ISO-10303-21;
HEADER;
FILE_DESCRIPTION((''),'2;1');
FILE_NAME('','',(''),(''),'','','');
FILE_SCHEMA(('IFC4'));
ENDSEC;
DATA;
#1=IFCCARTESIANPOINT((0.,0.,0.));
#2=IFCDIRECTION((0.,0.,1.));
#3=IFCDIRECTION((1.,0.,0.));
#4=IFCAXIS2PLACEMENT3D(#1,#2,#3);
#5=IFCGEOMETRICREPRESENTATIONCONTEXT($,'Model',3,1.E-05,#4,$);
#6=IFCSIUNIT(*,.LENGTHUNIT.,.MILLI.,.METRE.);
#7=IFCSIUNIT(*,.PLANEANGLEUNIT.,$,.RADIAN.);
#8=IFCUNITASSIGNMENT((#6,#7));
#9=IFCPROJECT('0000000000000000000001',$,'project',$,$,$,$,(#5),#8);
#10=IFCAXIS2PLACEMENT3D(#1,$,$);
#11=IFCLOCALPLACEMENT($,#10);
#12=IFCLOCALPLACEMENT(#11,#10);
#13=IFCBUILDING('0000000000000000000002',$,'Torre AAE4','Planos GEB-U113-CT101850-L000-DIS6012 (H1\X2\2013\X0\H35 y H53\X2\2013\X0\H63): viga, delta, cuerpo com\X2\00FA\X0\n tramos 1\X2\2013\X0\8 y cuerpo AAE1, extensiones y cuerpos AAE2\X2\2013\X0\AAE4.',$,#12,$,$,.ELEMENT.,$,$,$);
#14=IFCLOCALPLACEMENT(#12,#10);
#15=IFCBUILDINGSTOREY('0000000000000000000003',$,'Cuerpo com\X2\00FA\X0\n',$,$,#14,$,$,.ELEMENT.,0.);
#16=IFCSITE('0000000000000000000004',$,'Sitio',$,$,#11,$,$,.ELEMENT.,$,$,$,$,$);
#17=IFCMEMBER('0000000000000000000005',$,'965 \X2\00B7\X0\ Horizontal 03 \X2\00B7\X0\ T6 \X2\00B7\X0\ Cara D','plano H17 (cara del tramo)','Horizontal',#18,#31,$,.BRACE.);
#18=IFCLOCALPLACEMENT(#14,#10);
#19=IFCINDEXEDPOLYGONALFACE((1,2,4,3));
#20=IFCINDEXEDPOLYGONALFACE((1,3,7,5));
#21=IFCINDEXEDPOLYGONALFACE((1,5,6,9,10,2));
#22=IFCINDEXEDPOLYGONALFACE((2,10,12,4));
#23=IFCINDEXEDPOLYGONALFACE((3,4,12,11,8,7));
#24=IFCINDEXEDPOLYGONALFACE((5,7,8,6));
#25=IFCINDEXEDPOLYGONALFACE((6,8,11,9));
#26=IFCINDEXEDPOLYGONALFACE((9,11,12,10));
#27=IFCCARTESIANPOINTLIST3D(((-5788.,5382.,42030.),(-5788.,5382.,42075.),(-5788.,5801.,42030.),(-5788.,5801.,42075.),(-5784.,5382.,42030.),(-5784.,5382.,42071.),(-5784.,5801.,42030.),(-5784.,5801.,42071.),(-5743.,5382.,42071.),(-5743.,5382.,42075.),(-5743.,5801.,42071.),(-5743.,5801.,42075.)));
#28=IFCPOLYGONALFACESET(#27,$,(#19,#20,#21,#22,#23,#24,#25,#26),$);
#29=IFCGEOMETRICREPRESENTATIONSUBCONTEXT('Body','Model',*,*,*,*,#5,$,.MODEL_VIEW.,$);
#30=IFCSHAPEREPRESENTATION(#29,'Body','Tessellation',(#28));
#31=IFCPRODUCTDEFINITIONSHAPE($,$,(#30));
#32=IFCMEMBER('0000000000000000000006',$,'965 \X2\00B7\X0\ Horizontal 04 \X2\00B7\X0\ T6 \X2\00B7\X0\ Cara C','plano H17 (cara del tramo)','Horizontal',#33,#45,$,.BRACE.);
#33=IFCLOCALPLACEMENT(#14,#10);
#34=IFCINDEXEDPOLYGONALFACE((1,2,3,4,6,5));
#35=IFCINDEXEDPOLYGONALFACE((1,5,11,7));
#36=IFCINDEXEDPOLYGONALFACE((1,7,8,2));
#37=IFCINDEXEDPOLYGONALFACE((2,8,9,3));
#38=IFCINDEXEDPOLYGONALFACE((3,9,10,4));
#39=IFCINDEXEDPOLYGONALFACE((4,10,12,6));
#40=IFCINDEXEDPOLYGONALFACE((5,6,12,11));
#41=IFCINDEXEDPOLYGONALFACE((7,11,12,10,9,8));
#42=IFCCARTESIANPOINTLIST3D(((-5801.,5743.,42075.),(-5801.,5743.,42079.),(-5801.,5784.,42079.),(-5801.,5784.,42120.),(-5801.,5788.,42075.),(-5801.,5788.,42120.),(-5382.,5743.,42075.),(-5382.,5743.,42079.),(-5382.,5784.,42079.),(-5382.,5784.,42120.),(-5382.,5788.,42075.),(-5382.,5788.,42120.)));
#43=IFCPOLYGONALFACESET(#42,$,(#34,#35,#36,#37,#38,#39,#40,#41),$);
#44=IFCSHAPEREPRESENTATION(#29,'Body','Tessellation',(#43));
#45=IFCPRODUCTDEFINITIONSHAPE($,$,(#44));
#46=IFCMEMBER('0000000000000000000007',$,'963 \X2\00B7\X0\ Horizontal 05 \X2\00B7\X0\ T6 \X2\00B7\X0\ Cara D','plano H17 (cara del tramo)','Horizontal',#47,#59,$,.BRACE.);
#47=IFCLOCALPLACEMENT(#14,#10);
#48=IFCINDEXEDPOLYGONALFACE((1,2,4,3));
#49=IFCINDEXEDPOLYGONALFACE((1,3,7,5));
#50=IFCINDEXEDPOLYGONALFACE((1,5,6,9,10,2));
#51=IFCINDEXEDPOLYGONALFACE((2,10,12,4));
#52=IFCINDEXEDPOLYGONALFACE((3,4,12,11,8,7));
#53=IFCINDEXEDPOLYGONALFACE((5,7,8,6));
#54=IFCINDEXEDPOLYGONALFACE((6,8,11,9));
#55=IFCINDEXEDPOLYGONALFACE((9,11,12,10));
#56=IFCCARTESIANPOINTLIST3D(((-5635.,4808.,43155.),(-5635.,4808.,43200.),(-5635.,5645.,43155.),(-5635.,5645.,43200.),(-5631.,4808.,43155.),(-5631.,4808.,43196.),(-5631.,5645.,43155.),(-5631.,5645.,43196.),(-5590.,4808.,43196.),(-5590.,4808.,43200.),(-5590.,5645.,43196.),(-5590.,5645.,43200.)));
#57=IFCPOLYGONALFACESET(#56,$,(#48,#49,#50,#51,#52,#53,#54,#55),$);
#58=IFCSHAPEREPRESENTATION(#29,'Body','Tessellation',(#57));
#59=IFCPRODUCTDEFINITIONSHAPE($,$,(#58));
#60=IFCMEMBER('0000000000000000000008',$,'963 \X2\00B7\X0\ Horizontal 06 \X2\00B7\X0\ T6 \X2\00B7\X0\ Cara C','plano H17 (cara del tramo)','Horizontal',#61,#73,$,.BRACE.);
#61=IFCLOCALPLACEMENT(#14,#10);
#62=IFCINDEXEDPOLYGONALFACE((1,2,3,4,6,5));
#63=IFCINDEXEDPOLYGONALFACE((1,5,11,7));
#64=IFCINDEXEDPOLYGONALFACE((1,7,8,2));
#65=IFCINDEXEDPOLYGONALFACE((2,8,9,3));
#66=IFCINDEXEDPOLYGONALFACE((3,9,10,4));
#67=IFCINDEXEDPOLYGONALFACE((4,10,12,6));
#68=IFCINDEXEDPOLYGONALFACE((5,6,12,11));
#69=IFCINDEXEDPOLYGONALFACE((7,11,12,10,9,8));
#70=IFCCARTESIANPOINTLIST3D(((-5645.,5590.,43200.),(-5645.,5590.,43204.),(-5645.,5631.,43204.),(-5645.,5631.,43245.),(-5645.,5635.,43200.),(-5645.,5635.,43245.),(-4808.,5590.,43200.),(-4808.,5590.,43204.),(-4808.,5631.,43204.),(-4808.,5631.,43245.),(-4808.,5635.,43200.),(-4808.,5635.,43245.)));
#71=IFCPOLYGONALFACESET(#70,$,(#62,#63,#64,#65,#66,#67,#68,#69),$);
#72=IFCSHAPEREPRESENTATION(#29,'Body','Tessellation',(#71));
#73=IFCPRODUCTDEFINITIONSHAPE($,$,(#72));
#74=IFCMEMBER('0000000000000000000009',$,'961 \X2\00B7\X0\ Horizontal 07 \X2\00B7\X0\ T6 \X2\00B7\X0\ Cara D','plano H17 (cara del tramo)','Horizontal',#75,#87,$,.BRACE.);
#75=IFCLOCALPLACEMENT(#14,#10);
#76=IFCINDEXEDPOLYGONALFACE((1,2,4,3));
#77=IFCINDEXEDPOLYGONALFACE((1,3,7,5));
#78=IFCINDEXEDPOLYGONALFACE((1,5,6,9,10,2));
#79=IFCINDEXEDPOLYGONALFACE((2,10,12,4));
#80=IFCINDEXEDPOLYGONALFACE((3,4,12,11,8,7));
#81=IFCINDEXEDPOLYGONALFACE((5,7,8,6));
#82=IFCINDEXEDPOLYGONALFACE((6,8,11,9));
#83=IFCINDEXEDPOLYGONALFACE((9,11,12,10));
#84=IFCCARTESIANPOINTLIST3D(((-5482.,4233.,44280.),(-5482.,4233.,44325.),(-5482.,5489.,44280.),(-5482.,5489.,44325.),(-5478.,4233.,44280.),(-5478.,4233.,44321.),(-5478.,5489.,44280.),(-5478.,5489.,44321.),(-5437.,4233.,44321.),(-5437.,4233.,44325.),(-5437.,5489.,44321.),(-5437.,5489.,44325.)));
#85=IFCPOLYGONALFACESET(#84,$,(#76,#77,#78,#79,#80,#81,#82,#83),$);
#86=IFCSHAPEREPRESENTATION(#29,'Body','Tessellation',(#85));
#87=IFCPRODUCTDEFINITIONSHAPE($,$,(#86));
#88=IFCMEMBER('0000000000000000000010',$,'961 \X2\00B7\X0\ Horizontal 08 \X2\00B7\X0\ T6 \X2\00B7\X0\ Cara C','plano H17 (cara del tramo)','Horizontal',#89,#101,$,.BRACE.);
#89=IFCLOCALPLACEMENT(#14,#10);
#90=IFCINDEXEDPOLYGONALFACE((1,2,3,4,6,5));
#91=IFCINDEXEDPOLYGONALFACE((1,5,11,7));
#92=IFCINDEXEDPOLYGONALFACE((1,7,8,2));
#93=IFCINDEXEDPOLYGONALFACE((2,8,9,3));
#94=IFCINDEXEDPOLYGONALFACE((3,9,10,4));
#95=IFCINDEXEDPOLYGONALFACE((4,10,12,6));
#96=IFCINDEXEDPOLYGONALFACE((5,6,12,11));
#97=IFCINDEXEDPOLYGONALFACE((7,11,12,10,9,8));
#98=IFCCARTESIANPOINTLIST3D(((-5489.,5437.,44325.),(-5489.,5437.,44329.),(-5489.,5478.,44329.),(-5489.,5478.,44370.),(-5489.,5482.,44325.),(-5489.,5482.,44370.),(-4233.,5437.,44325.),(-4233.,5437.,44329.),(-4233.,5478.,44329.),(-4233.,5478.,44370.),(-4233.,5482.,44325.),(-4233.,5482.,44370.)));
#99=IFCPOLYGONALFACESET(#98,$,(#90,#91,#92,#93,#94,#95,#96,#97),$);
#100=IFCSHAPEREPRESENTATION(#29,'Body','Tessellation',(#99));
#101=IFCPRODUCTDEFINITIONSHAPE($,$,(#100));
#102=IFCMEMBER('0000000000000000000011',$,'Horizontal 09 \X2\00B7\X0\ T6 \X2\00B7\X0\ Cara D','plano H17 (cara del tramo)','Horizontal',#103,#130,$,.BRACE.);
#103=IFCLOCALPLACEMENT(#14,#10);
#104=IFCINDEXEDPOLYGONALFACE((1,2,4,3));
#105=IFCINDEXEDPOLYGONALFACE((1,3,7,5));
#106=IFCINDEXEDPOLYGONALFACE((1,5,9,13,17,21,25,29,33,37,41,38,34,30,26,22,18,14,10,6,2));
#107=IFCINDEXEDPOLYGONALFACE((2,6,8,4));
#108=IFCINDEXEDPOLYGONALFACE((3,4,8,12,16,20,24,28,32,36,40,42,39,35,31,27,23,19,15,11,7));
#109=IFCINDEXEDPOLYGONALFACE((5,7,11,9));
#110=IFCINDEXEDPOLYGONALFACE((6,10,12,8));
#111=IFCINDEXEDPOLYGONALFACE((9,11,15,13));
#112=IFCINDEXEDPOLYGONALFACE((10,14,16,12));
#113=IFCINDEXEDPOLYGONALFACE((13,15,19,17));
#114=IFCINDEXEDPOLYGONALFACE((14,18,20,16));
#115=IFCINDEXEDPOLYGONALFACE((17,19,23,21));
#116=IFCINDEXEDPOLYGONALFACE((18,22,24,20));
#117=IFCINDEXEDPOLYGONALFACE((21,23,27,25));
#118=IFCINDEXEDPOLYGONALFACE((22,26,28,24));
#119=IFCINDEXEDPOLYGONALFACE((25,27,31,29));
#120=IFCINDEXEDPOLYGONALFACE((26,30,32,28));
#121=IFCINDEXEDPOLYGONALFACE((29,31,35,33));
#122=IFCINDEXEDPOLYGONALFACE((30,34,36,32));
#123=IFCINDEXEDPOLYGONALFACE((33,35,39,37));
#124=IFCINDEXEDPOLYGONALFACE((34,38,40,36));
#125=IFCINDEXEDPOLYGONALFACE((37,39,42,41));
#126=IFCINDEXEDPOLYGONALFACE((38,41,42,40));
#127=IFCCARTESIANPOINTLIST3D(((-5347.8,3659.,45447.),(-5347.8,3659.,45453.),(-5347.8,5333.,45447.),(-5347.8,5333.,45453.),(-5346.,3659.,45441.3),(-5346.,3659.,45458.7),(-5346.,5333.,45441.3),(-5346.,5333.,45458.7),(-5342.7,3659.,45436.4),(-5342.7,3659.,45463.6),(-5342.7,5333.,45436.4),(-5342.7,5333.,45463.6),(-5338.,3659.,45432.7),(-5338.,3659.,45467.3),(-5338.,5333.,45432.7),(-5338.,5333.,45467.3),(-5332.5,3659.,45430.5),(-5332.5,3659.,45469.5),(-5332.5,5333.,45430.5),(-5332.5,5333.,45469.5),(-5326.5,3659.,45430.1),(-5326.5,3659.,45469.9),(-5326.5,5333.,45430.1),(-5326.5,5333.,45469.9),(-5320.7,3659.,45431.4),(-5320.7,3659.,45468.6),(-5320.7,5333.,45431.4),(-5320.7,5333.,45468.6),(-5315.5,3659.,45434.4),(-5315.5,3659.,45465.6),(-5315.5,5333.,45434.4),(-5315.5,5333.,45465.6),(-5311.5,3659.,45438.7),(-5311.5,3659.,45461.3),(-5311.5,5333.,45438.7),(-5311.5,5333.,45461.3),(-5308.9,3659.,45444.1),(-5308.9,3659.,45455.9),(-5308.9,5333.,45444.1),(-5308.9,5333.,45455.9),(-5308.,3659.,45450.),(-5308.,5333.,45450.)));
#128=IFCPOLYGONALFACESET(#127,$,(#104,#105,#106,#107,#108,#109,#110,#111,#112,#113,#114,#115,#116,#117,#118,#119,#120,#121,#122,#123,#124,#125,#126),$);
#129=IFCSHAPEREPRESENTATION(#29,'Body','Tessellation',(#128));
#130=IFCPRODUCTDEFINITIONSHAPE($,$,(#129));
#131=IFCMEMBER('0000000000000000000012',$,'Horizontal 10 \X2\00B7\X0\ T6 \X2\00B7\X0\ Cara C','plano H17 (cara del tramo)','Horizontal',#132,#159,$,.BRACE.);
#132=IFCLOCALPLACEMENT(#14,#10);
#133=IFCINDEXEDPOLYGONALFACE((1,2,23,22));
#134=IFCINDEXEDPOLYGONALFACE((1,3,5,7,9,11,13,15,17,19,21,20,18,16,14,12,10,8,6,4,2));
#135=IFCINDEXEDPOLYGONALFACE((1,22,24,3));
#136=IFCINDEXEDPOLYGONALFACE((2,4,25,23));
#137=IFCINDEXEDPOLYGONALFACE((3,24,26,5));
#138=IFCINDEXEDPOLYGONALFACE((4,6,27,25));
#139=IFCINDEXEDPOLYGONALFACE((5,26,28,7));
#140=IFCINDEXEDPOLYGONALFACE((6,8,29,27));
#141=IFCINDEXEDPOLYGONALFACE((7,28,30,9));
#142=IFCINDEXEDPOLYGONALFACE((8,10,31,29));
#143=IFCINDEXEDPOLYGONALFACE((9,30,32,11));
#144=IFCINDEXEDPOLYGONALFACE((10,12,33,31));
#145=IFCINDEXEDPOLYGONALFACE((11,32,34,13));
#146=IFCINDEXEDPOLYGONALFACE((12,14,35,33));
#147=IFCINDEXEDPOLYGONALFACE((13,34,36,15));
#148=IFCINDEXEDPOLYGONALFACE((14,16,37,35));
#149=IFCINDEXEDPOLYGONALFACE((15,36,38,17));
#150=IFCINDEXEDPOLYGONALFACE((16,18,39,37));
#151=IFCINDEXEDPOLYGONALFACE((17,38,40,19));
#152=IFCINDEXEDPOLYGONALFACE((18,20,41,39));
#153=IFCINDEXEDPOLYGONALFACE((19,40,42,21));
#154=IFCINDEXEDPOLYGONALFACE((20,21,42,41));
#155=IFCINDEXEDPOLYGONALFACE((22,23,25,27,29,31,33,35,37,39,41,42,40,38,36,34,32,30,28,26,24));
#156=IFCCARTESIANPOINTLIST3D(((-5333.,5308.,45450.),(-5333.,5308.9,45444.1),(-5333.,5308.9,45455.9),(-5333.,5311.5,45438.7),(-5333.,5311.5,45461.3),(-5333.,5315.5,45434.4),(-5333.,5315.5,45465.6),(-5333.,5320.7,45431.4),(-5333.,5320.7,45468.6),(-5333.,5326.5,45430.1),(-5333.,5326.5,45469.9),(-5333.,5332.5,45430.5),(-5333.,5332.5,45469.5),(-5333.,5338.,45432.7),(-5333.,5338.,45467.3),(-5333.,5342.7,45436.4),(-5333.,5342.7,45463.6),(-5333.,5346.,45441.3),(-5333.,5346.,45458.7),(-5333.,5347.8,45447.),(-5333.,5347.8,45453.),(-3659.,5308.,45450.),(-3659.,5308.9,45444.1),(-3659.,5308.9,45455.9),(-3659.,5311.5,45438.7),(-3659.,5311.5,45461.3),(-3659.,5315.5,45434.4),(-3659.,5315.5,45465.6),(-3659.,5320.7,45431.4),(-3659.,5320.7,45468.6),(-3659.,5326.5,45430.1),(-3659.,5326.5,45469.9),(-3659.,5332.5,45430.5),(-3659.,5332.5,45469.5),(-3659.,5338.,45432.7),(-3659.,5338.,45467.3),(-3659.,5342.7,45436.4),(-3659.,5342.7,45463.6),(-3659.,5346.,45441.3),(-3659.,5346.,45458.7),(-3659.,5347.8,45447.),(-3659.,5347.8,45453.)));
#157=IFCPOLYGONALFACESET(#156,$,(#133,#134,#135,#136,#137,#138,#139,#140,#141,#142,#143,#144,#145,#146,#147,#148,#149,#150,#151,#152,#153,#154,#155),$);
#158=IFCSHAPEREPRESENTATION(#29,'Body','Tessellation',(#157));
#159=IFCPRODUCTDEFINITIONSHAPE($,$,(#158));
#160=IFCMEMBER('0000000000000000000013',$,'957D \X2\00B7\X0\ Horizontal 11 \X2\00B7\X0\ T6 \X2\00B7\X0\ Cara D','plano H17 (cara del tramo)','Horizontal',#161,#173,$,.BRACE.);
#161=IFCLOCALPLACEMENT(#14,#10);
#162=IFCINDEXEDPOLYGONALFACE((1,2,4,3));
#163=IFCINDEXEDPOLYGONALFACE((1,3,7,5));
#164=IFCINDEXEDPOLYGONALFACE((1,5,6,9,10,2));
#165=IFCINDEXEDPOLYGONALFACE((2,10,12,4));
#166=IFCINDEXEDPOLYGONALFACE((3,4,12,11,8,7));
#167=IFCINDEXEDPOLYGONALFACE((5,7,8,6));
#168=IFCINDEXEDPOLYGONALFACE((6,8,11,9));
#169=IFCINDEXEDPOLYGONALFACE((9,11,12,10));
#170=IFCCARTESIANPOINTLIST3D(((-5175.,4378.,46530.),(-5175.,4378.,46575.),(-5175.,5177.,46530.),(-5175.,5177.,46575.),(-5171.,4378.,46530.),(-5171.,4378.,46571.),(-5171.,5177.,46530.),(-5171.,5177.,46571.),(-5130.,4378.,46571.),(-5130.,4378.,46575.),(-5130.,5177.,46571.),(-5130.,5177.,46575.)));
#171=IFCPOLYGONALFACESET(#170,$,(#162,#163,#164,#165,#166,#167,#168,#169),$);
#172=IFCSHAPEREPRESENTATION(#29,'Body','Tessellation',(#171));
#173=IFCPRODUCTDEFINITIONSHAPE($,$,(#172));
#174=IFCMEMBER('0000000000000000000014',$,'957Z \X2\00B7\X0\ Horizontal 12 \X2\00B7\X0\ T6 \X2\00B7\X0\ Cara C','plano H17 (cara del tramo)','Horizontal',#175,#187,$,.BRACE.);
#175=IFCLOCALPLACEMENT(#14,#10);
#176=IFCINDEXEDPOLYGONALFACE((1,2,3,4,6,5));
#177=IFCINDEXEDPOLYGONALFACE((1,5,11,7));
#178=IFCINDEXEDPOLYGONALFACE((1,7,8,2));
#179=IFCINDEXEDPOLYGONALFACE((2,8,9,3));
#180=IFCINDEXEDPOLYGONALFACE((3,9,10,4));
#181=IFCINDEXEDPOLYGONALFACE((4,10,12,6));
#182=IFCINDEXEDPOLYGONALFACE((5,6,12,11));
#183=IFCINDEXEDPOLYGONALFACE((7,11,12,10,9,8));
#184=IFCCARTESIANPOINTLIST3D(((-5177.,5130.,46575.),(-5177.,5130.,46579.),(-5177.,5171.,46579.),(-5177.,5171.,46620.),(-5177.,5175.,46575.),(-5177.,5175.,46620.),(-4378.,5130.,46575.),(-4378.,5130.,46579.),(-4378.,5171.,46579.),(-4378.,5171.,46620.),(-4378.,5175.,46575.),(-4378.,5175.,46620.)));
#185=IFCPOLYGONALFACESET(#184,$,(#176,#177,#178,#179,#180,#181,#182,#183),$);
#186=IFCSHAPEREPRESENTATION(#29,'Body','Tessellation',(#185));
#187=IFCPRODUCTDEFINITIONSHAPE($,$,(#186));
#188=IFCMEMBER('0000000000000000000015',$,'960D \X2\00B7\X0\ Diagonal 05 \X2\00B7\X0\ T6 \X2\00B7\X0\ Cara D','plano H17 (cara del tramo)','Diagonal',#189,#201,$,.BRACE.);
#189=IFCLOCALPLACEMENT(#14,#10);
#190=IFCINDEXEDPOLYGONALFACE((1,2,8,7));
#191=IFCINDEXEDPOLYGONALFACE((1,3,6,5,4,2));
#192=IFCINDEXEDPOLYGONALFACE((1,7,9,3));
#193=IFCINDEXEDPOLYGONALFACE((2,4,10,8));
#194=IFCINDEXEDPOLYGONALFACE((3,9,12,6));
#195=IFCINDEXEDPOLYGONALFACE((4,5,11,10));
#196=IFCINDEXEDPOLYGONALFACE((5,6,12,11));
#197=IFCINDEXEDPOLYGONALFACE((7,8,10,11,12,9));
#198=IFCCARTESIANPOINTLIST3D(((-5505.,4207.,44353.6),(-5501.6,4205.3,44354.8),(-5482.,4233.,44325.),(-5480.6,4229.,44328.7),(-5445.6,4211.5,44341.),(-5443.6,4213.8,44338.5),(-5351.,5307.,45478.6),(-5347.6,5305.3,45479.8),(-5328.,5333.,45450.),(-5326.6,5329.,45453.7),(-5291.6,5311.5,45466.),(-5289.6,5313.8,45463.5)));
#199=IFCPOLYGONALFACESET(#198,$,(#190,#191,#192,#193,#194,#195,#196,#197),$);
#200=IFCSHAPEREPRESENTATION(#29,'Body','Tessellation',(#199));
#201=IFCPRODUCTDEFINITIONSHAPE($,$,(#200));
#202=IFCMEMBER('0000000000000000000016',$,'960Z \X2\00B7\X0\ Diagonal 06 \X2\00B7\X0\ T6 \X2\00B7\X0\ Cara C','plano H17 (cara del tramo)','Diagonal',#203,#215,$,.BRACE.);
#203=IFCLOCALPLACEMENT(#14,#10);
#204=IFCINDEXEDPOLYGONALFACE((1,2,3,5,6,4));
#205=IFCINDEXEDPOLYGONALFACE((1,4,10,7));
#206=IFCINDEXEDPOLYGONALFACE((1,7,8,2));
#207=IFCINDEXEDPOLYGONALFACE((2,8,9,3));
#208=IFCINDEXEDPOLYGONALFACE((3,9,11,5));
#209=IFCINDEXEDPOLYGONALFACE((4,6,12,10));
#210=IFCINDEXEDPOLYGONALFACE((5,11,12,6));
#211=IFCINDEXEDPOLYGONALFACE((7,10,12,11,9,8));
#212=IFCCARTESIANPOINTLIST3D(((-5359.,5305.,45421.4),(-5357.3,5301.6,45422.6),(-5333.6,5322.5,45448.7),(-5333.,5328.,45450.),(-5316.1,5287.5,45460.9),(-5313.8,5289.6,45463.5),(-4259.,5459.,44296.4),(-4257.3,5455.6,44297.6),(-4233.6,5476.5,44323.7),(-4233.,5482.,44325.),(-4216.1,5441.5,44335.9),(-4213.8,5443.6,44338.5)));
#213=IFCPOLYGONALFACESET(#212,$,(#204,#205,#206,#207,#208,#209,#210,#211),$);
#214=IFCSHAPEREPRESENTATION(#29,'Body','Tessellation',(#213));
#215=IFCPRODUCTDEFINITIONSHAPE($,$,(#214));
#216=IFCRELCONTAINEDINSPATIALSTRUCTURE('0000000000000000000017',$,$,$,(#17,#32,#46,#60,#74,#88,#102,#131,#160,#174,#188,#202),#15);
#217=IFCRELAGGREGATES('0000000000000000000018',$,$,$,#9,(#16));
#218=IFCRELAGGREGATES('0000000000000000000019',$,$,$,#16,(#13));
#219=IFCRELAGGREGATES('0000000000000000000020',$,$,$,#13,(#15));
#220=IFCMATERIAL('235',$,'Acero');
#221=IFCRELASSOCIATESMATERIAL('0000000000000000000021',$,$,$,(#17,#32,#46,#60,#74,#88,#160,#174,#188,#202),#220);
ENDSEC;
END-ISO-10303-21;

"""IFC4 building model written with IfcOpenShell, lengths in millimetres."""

from ifc_helpers import new_model, si_unit, frame, frame_2d, origin, origin_with_axes, place, context, subcontext, project, spatial, circle, l_section, extrude, material, element, save


model = new_model("IFC4")

# Units and contexts
model_context = context("Model", 3, precision=1e-05, world=origin_with_axes())
body_context = subcontext(model_context, "Body", "Model", "MODEL_VIEW")
ifc_project = project(units=[si_unit("LENGTHUNIT", "METRE", prefix="MILLI"), si_unit("PLANEANGLEUNIT", "RADIAN")], contexts=[model_context])

# Site, building, storey
site_placement = place(None, origin())
site = spatial("IfcSite", under=ifc_project, at=site_placement, Name="Sitio", CompositionType="ELEMENT")
building_placement = place(site_placement, origin())
building = spatial("IfcBuilding", under=site, at=building_placement, Name="Torre AAE4", Description="Planos GEB-U113-CT101850-L000-DIS6012 (H1–H35 y H53–H63): viga, delta, cuerpo común tramos 1–8 y cuerpo AAE1, extensiones y cuerpos AAE2–AAE4.", CompositionType="ELEMENT")
storey_placement = place(building_placement, origin())
storey = spatial("IfcBuildingStorey", under=building, at=storey_placement, Name="Cuerpo común", CompositionType="ELEMENT", Elevation=0.0)

# Members
ifc_material_1 = material(Name="235", Category="Acero")
for number, where, z_axis, x_axis, name in (
    (1, (-5788.0, 5382.0, 42075.0), (0.0, 1.0, 0.0), (1.0, 0.0, 0.0), "965 · Horizontal 03 · T6 · Cara D"),
    (2, (-5382.0, 5788.0, 42075.0), (-1.0, 0.0, 0.0), (0.0, -1.0, 0.0), "965 · Horizontal 04 · T6 · Cara C"),
):
    element("IfcMember", number, at=place(storey_placement, frame(where, z_axis=z_axis, x_axis=x_axis)), inside=storey, material=ifc_material_1, Name=name, Description="plano H17 (cara del tramo)", ObjectType="Horizontal", PredefinedType="BRACE", context=body_context, shape_type="SweptSolid", body=[
        extrude(l_section(Depth=45.0, Width=45.0, Thickness=4.0, at=frame_2d((22.5, 22.5))), None, (0.0, 0.0, 1.0), 419.0),
    ])
for number, where, z_axis, x_axis, name in (
    (3, (-5635.0, 4808.0, 43200.0), (0.0, 1.0, 0.0), (1.0, 0.0, 0.0), "963 · Horizontal 05 · T6 · Cara D"),
    (4, (-4808.0, 5635.0, 43200.0), (-1.0, 0.0, 0.0), (0.0, -1.0, 0.0), "963 · Horizontal 06 · T6 · Cara C"),
):
    element("IfcMember", number, at=place(storey_placement, frame(where, z_axis=z_axis, x_axis=x_axis)), inside=storey, material=ifc_material_1, Name=name, Description="plano H17 (cara del tramo)", ObjectType="Horizontal", PredefinedType="BRACE", context=body_context, shape_type="SweptSolid", body=[
        extrude(l_section(Depth=45.0, Width=45.0, Thickness=4.0, at=frame_2d((22.5, 22.5))), None, (0.0, 0.0, 1.0), 837.0),
    ])
for number, where, z_axis, x_axis, name in (
    (5, (-5482.0, 4233.0, 44325.0), (0.0, 1.0, 0.0), (1.0, 0.0, 0.0), "961 · Horizontal 07 · T6 · Cara D"),
    (6, (-4233.0, 5482.0, 44325.0), (-1.0, 0.0, 0.0), (0.0, -1.0, 0.0), "961 · Horizontal 08 · T6 · Cara C"),
):
    element("IfcMember", number, at=place(storey_placement, frame(where, z_axis=z_axis, x_axis=x_axis)), inside=storey, material=ifc_material_1, Name=name, Description="plano H17 (cara del tramo)", ObjectType="Horizontal", PredefinedType="BRACE", context=body_context, shape_type="SweptSolid", body=[
        extrude(l_section(Depth=45.0, Width=45.0, Thickness=4.0, at=frame_2d((22.5, 22.5))), None, (0.0, 0.0, 1.0), 1256.0),
    ])
for number, where, z_axis, x_axis, name in (
    (7, (-5328.0, 3659.0, 45450.0), (0.0, 1.0, 0.0), (1.0, 0.0, 0.0), "Horizontal 09 · T6 · Cara D"),
    (8, (-3659.0, 5328.0, 45450.0), (-1.0, 0.0, 0.0), (0.0, -1.0, 0.0), "Horizontal 10 · T6 · Cara C"),
):
    element("IfcMember", number, at=place(storey_placement, frame(where, z_axis=z_axis, x_axis=x_axis)), inside=storey, Name=name, Description="plano H17 (cara del tramo)", ObjectType="Horizontal", PredefinedType="BRACE", context=body_context, shape_type="SweptSolid", body=[
        extrude(circle(Radius=20.0), None, (0.0, 0.0, 1.0), 1674.0),
    ])
for number, where, z_axis, x_axis, name in (
    (9, (-5175.0, 4378.0, 46575.0), (0.0, 1.0, 0.0), (1.0, 0.0, 0.0), "957D · Horizontal 11 · T6 · Cara D"),
    (10, (-4378.0, 5175.0, 46575.0), (-1.0, 0.0, 0.0), (0.0, -1.0, 0.0), "957Z · Horizontal 12 · T6 · Cara C"),
):
    element("IfcMember", number, at=place(storey_placement, frame(where, z_axis=z_axis, x_axis=x_axis)), inside=storey, material=ifc_material_1, Name=name, Description="plano H17 (cara del tramo)", ObjectType="Horizontal", PredefinedType="BRACE", context=body_context, shape_type="SweptSolid", body=[
        extrude(l_section(Depth=45.0, Width=45.0, Thickness=4.0, at=frame_2d((22.5, 22.5))), None, (0.0, 0.0, 1.0), 799.0),
    ])
for number, where, z_axis, x_axis, name in (
    (11, (-5328.0, 5333.0, 45450.0), (-0.097411, -0.695793, -0.711606), (0.853622, -0.426031, 0.299712), "960D · Diagonal 05 · T6 · Cara D"),
    (12, (-5333.0, 5328.0, 45450.0), (0.695793, 0.097411, -0.711606), (0.426031, -0.853622, 0.299712), "960Z · Diagonal 06 · T6 · Cara C"),
):
    element("IfcMember", number, at=place(storey_placement, frame(where, z_axis=z_axis, x_axis=x_axis)), inside=storey, material=ifc_material_1, Name=name, Description="plano H17 (cara del tramo)", ObjectType="Diagonal", PredefinedType="BRACE", context=body_context, shape_type="SweptSolid", body=[
        extrude(l_section(Depth=45.0, Width=45.0, Thickness=4.0, at=frame_2d((22.5, 22.5))), None, (0.0, 0.0, 1.0), 1580.9),
    ])

save(model, "model.ifc")
